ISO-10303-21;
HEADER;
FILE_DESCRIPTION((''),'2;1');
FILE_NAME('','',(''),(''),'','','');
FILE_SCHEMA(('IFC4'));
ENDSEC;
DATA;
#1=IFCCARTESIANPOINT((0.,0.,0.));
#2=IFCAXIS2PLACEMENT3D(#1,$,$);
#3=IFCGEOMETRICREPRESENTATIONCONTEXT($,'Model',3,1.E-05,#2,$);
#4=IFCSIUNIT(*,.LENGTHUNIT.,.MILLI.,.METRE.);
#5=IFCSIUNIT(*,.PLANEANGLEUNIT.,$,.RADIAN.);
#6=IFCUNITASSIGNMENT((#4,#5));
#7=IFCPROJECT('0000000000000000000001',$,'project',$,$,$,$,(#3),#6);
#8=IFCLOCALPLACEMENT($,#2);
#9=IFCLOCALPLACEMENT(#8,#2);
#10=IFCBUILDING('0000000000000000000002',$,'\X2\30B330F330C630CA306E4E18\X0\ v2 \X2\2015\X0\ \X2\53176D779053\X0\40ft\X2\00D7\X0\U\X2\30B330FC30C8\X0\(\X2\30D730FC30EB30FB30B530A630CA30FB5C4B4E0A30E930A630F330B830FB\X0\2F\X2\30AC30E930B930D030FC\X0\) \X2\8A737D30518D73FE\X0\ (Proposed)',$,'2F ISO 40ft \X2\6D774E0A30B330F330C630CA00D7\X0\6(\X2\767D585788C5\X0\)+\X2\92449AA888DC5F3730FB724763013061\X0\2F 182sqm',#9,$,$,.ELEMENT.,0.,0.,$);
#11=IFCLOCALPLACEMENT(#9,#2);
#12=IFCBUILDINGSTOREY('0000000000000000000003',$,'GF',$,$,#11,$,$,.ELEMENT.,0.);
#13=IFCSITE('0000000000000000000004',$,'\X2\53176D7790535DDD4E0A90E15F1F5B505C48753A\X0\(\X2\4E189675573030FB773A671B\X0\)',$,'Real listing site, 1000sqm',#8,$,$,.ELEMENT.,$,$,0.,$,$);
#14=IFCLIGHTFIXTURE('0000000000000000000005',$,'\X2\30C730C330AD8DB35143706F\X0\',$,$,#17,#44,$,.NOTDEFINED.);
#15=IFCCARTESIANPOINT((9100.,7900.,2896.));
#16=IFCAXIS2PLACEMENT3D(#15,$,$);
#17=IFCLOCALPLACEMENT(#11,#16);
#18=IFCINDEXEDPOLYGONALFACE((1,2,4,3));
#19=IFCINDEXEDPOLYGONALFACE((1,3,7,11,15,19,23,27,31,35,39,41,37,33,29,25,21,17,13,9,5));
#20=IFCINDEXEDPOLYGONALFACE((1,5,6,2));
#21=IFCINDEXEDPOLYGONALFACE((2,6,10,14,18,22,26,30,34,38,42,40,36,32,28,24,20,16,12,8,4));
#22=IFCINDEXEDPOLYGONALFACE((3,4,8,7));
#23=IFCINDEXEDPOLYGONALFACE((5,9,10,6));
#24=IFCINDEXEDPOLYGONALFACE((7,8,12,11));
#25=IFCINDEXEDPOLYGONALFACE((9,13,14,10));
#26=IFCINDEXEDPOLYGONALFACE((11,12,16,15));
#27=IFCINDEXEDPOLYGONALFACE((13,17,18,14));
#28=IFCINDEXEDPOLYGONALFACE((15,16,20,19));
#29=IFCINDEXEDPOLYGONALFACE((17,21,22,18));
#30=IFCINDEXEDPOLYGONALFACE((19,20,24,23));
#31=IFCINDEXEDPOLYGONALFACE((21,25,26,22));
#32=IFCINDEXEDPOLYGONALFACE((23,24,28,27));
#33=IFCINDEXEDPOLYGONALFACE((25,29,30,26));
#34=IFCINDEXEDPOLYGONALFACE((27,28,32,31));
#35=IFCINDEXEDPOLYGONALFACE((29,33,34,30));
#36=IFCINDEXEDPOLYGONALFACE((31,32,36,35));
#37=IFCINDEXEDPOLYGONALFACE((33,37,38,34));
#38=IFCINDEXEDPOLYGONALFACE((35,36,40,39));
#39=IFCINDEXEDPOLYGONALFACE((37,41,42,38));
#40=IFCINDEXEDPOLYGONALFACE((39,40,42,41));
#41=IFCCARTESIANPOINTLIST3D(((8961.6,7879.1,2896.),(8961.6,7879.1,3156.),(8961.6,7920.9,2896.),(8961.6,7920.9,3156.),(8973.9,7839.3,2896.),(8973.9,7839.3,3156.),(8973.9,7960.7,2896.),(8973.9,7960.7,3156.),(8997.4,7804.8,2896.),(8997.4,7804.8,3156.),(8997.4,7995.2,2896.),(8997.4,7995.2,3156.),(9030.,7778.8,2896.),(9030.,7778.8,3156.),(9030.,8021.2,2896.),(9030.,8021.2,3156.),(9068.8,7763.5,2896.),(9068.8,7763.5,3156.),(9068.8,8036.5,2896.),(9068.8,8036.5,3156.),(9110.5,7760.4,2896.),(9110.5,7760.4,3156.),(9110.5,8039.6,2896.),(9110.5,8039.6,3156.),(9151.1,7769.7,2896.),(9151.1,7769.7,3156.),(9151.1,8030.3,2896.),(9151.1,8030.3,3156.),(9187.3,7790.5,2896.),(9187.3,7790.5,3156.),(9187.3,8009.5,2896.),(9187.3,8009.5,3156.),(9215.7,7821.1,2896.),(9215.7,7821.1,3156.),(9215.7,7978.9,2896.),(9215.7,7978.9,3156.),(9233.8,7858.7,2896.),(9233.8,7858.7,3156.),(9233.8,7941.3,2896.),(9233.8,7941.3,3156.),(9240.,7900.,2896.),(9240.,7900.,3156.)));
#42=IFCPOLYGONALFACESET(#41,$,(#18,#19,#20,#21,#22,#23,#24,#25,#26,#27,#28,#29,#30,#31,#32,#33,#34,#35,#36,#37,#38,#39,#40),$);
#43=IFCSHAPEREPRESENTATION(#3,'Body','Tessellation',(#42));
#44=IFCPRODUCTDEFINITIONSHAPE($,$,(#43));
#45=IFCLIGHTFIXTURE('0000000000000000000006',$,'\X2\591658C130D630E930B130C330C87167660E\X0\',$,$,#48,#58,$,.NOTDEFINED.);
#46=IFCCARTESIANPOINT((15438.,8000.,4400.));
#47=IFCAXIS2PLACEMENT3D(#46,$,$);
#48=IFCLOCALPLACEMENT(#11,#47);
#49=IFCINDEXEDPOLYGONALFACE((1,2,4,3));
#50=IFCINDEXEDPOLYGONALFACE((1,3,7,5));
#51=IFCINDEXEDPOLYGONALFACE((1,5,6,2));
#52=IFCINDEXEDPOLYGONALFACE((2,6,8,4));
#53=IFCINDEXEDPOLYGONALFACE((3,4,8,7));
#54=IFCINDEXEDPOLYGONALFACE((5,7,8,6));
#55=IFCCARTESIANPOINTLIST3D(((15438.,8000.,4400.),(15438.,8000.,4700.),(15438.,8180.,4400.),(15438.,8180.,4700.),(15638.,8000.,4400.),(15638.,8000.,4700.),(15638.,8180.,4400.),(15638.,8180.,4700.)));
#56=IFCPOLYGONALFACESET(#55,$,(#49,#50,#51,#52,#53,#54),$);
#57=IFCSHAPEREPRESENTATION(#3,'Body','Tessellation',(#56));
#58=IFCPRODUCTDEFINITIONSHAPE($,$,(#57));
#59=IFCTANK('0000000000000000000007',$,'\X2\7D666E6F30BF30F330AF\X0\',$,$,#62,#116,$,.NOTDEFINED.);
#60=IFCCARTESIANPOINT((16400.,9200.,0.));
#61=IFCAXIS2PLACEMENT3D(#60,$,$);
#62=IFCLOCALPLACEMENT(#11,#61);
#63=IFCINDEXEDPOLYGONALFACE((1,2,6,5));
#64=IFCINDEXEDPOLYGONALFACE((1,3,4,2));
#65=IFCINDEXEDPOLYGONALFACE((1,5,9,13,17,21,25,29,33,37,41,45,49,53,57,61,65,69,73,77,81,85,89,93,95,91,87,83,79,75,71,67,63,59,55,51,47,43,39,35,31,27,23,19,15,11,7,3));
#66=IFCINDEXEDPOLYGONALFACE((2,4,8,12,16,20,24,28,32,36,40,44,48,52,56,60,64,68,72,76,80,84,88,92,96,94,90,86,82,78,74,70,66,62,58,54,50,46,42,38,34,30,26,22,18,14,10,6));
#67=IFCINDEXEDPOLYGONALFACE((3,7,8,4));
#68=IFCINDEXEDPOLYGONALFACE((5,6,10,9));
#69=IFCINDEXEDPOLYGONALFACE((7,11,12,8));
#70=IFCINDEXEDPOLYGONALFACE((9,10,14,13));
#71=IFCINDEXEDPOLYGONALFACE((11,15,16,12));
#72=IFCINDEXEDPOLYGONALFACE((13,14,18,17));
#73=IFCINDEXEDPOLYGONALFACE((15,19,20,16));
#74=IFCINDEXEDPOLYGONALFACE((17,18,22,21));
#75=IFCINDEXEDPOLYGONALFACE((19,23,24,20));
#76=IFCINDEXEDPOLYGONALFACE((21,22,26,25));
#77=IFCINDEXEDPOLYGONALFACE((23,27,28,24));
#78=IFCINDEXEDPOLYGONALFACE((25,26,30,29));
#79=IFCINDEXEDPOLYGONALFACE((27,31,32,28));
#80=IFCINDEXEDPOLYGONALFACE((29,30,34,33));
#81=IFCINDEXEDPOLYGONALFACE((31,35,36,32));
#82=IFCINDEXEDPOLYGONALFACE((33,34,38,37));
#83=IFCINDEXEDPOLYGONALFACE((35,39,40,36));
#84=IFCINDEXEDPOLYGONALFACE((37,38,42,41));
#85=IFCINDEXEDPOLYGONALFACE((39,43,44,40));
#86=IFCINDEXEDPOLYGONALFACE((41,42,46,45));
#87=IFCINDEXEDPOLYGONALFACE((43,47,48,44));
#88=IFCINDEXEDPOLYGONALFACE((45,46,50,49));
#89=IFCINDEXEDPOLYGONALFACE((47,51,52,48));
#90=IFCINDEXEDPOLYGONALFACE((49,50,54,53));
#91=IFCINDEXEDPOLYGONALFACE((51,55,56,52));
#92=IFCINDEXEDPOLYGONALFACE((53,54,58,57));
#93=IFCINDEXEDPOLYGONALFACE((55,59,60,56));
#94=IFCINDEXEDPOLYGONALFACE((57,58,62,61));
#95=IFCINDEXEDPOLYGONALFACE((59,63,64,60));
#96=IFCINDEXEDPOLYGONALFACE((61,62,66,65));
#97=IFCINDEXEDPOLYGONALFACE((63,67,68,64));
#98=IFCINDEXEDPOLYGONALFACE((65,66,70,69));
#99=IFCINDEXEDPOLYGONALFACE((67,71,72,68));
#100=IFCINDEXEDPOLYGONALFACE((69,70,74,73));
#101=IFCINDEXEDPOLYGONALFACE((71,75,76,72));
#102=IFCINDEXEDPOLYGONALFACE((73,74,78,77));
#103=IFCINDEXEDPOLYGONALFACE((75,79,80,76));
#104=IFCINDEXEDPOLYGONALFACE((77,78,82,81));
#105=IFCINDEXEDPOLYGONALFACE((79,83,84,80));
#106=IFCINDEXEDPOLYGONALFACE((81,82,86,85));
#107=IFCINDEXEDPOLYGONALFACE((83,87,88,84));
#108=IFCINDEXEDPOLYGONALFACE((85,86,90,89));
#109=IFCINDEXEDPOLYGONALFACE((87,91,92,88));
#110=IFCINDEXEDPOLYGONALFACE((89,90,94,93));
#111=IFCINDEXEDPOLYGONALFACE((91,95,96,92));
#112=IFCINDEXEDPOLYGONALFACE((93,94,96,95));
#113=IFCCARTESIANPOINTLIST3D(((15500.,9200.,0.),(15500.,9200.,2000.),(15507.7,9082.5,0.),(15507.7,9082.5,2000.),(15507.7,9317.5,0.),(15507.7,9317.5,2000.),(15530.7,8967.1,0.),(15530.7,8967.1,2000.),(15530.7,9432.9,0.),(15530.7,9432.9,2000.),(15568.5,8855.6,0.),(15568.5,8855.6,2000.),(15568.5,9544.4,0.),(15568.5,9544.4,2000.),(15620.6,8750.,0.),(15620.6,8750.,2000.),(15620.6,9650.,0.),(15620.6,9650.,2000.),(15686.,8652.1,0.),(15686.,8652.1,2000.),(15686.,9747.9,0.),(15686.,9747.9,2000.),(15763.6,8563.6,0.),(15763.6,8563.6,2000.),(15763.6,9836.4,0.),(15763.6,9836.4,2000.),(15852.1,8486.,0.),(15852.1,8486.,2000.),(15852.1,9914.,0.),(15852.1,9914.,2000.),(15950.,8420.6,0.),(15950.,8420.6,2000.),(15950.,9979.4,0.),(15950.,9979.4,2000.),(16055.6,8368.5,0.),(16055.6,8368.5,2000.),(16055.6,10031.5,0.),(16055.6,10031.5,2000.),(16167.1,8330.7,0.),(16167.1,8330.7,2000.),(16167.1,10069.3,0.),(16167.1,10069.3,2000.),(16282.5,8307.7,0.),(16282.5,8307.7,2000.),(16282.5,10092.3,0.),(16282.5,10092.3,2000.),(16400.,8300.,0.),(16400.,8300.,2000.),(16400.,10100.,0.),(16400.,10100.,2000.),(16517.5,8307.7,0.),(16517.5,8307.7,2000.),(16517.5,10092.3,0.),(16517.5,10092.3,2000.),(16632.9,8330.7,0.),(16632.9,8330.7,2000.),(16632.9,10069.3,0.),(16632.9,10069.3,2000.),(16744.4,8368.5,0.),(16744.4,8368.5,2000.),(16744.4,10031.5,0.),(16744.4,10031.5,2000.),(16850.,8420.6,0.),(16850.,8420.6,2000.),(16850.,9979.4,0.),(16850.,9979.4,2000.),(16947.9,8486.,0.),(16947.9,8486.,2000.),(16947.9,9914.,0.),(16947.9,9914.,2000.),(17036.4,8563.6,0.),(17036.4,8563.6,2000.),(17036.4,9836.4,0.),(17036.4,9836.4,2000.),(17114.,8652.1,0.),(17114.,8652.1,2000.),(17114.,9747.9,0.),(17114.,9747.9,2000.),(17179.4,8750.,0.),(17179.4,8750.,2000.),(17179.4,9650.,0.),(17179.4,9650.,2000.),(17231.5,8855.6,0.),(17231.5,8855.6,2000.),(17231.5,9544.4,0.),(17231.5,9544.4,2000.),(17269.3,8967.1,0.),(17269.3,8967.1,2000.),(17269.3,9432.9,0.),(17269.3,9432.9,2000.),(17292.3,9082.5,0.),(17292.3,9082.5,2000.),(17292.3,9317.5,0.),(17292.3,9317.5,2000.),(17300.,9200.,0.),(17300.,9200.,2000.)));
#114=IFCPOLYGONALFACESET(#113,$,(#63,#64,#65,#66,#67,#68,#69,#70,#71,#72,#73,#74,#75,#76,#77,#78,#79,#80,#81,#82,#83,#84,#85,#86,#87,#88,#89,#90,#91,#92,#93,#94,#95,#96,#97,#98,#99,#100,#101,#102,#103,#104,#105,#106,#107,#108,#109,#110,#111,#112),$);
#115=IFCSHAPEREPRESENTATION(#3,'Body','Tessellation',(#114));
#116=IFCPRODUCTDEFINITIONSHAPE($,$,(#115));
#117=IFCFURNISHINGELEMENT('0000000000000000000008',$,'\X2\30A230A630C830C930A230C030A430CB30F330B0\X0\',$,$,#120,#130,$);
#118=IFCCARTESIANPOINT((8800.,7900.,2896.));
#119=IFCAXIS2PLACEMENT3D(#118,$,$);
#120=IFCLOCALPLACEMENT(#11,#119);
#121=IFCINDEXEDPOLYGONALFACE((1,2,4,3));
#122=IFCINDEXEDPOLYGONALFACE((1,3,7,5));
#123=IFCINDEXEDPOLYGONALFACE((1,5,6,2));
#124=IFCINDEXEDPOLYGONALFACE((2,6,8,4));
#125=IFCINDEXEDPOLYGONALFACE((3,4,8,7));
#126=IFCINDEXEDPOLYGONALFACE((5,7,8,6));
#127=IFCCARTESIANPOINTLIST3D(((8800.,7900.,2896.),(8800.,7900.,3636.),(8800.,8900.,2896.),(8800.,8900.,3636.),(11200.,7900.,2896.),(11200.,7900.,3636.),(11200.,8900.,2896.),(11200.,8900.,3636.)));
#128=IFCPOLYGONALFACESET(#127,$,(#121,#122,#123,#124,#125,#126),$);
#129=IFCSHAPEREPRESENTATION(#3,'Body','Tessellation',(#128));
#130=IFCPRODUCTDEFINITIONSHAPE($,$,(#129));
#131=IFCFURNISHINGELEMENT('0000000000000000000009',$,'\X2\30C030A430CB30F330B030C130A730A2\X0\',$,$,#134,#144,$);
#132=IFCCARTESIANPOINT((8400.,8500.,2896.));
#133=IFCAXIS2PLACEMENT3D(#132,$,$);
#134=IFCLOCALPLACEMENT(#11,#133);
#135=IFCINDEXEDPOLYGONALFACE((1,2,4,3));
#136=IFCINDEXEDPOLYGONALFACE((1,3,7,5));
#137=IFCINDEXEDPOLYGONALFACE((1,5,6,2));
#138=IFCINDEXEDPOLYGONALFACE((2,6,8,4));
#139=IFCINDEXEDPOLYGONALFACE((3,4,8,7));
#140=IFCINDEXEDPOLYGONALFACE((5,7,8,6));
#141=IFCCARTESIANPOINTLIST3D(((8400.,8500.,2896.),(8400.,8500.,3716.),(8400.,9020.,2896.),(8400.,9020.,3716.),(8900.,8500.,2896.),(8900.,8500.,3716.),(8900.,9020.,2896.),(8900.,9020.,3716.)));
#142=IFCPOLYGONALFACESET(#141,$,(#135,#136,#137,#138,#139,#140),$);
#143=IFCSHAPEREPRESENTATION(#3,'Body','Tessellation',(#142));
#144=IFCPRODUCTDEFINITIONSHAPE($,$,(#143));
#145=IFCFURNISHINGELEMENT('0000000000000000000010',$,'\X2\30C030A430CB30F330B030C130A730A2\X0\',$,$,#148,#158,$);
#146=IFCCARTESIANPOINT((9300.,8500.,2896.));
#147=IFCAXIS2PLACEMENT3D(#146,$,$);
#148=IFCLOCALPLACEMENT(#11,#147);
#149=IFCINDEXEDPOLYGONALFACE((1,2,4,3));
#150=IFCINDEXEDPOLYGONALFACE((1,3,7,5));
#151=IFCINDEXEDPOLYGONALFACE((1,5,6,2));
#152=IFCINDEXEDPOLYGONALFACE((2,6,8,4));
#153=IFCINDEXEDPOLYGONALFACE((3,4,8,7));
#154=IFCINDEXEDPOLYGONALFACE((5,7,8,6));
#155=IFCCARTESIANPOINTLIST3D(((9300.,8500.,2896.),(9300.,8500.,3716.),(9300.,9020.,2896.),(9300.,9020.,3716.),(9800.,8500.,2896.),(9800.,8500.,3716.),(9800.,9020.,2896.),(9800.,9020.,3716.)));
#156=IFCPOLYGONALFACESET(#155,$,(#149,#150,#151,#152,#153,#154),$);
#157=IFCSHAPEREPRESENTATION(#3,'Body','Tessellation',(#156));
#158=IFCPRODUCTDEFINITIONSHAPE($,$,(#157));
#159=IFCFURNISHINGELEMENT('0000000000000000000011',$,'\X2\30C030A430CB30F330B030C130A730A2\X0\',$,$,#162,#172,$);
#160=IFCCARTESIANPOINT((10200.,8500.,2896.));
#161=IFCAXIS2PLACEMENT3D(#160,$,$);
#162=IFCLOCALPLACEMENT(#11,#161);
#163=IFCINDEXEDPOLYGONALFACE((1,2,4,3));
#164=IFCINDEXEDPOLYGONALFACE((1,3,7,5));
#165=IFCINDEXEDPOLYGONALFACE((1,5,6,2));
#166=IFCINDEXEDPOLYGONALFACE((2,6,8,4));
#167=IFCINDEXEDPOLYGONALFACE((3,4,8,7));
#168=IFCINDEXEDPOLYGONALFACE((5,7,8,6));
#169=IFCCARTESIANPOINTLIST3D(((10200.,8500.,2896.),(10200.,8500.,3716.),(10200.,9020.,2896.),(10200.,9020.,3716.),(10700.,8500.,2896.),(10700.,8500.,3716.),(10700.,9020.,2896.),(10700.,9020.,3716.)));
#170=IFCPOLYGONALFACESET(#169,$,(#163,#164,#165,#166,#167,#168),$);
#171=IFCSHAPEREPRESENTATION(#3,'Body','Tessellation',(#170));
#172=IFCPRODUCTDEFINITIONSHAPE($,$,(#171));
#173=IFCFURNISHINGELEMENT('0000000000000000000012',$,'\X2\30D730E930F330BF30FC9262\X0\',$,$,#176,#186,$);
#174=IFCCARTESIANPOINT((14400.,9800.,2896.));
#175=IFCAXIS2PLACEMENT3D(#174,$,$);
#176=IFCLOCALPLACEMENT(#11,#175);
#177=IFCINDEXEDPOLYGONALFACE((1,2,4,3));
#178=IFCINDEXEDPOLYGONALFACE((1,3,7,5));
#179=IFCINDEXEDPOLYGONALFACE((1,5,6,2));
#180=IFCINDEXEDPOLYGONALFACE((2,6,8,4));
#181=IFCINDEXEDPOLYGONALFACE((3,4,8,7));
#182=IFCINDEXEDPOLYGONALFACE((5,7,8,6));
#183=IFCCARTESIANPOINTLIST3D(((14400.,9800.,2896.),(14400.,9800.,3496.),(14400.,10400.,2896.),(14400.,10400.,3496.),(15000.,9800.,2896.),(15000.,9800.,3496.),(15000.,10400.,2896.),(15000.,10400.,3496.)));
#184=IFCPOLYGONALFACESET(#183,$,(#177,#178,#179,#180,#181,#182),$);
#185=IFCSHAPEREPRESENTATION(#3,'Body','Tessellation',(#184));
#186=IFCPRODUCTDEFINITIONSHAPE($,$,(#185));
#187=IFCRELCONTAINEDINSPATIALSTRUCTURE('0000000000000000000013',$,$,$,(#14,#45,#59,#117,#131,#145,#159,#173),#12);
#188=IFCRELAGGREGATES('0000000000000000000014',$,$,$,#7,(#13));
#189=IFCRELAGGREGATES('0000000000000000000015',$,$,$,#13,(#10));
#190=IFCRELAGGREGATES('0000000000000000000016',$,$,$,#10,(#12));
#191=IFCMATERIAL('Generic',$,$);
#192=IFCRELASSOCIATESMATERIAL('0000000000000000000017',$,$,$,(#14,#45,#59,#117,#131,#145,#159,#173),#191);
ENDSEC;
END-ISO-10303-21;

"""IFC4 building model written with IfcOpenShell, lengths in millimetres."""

from ifc_helpers import new_model, si_unit, frame, frame_2d, origin, origin_2d, place, context, project, spatial, rectangle, circle, extrude, material, element, save


model = new_model("IFC4")

# Units and contexts
model_context = context("Model", 3, precision=1e-05, world=origin())
ifc_project = project(units=[si_unit("LENGTHUNIT", "METRE", prefix="MILLI"), si_unit("PLANEANGLEUNIT", "RADIAN")], contexts=[model_context])

# Site, building, storey
site_placement = place(None, origin())
site = spatial("IfcSite", under=ifc_project, at=site_placement, Name="北海道川上郡弟子屈町(丘陵地・眺望)", ObjectType="Real listing site, 1000sqm", CompositionType="ELEMENT", RefElevation=0.0)
building_placement = place(site_placement, origin())
building = spatial("IfcBuilding", under=site, at=building_placement, Name="コンテナの丘 v2 ― 北海道40ft×Uコート(プール・サウナ・屋上ラウンジ・2Fガラスバー) 詳細再現 (Proposed)", ObjectType="2F ISO 40ft 海上コンテナ×6(白塗装)+鉄骨補強・片持ち2F 182sqm", CompositionType="ELEMENT", ElevationOfRefHeight=0.0, ElevationOfTerrain=0.0)
storey_placement = place(building_placement, origin())
storey = spatial("IfcBuildingStorey", under=building, at=storey_placement, Name="GF", CompositionType="ELEMENT", Elevation=0.0)

# Shared definitions
ifc_material = material(Name="Generic")

# Light fixtures
light_fixture_1_placement = place(storey_placement, frame((9100.0, 7900.0, 2896.0)))
element("IfcLightFixture", 1, at=light_fixture_1_placement, inside=storey, material=ifc_material, Name="デッキ足元灯", PredefinedType="NOTDEFINED", context=model_context, shape_type="SweptSolid", body=[
    extrude(circle(Radius=140.0, at=origin_2d()), frame((9100.0, 7900.0, 2896.0)), (0.0, 0.0, 1.0), 260.0),
])
light_fixture_2_placement = place(storey_placement, frame((15438.0, 8000.0, 4400.0)))
element("IfcLightFixture", 2, at=light_fixture_2_placement, inside=storey, material=ifc_material, Name="外壁ブラケット照明", PredefinedType="NOTDEFINED", context=model_context, shape_type="SweptSolid", body=[
    extrude(rectangle(XDim=200.0, YDim=180.0, at=frame_2d((100.0, 90.0))), frame((15438.0, 8000.0, 4400.0)), (0.0, 0.0, 1.0), 300.0),
])

# Tank
tank_placement = place(storey_placement, frame((16400.0, 9200.0, 0.0)))
element("IfcTank", 3, at=tank_placement, inside=storey, material=ifc_material, Name="給湯タンク", PredefinedType="NOTDEFINED", context=model_context, shape_type="SweptSolid", body=[
    extrude(circle(Radius=900.0, at=origin_2d()), frame((16400.0, 9200.0, 0.0)), (0.0, 0.0, 1.0), 2000.0),
])

# Furnishing elements
furnishing_1_placement = place(storey_placement, frame((8800.0, 7900.0, 2896.0)))
element("IfcFurnishingElement", 4, at=furnishing_1_placement, inside=storey, material=ifc_material, Name="アウトドアダイニング", context=model_context, shape_type="SweptSolid", body=[
    extrude(rectangle(XDim=2400.0, YDim=1000.0, at=frame_2d((1200.0, 500.0))), frame((8800.0, 7900.0, 2896.0)), (0.0, 0.0, 1.0), 740.0),
])
furnishing_2_placement = place(storey_placement, frame((8400.0, 8500.0, 2896.0)))
element("IfcFurnishingElement", 5, at=furnishing_2_placement, inside=storey, material=ifc_material, Name="ダイニングチェア", context=model_context, shape_type="SweptSolid", body=[
    extrude(rectangle(XDim=500.0, YDim=520.0, at=frame_2d((250.0, 260.0))), frame((8400.0, 8500.0, 2896.0)), (0.0, 0.0, 1.0), 820.0),
])
furnishing_3_placement = place(storey_placement, frame((9300.0, 8500.0, 2896.0)))
element("IfcFurnishingElement", 6, at=furnishing_3_placement, inside=storey, material=ifc_material, Name="ダイニングチェア", context=model_context, shape_type="SweptSolid", body=[
    extrude(rectangle(XDim=500.0, YDim=520.0, at=frame_2d((250.0, 260.0))), frame((9300.0, 8500.0, 2896.0)), (0.0, 0.0, 1.0), 820.0),
])
furnishing_4_placement = place(storey_placement, frame((10200.0, 8500.0, 2896.0)))
element("IfcFurnishingElement", 7, at=furnishing_4_placement, inside=storey, material=ifc_material, Name="ダイニングチェア", context=model_context, shape_type="SweptSolid", body=[
    extrude(rectangle(XDim=500.0, YDim=520.0, at=frame_2d((250.0, 260.0))), frame((10200.0, 8500.0, 2896.0)), (0.0, 0.0, 1.0), 820.0),
])
furnishing_5_placement = place(storey_placement, frame((14400.0, 9800.0, 2896.0)))
element("IfcFurnishingElement", 8, at=furnishing_5_placement, inside=storey, material=ifc_material, Name="プランター鉢", context=model_context, shape_type="SweptSolid", body=[
    extrude(rectangle(XDim=600.0, YDim=600.0, at=frame_2d((300.0, 300.0))), frame((14400.0, 9800.0, 2896.0)), (0.0, 0.0, 1.0), 600.0),
])

save(model, "model.ifc")
